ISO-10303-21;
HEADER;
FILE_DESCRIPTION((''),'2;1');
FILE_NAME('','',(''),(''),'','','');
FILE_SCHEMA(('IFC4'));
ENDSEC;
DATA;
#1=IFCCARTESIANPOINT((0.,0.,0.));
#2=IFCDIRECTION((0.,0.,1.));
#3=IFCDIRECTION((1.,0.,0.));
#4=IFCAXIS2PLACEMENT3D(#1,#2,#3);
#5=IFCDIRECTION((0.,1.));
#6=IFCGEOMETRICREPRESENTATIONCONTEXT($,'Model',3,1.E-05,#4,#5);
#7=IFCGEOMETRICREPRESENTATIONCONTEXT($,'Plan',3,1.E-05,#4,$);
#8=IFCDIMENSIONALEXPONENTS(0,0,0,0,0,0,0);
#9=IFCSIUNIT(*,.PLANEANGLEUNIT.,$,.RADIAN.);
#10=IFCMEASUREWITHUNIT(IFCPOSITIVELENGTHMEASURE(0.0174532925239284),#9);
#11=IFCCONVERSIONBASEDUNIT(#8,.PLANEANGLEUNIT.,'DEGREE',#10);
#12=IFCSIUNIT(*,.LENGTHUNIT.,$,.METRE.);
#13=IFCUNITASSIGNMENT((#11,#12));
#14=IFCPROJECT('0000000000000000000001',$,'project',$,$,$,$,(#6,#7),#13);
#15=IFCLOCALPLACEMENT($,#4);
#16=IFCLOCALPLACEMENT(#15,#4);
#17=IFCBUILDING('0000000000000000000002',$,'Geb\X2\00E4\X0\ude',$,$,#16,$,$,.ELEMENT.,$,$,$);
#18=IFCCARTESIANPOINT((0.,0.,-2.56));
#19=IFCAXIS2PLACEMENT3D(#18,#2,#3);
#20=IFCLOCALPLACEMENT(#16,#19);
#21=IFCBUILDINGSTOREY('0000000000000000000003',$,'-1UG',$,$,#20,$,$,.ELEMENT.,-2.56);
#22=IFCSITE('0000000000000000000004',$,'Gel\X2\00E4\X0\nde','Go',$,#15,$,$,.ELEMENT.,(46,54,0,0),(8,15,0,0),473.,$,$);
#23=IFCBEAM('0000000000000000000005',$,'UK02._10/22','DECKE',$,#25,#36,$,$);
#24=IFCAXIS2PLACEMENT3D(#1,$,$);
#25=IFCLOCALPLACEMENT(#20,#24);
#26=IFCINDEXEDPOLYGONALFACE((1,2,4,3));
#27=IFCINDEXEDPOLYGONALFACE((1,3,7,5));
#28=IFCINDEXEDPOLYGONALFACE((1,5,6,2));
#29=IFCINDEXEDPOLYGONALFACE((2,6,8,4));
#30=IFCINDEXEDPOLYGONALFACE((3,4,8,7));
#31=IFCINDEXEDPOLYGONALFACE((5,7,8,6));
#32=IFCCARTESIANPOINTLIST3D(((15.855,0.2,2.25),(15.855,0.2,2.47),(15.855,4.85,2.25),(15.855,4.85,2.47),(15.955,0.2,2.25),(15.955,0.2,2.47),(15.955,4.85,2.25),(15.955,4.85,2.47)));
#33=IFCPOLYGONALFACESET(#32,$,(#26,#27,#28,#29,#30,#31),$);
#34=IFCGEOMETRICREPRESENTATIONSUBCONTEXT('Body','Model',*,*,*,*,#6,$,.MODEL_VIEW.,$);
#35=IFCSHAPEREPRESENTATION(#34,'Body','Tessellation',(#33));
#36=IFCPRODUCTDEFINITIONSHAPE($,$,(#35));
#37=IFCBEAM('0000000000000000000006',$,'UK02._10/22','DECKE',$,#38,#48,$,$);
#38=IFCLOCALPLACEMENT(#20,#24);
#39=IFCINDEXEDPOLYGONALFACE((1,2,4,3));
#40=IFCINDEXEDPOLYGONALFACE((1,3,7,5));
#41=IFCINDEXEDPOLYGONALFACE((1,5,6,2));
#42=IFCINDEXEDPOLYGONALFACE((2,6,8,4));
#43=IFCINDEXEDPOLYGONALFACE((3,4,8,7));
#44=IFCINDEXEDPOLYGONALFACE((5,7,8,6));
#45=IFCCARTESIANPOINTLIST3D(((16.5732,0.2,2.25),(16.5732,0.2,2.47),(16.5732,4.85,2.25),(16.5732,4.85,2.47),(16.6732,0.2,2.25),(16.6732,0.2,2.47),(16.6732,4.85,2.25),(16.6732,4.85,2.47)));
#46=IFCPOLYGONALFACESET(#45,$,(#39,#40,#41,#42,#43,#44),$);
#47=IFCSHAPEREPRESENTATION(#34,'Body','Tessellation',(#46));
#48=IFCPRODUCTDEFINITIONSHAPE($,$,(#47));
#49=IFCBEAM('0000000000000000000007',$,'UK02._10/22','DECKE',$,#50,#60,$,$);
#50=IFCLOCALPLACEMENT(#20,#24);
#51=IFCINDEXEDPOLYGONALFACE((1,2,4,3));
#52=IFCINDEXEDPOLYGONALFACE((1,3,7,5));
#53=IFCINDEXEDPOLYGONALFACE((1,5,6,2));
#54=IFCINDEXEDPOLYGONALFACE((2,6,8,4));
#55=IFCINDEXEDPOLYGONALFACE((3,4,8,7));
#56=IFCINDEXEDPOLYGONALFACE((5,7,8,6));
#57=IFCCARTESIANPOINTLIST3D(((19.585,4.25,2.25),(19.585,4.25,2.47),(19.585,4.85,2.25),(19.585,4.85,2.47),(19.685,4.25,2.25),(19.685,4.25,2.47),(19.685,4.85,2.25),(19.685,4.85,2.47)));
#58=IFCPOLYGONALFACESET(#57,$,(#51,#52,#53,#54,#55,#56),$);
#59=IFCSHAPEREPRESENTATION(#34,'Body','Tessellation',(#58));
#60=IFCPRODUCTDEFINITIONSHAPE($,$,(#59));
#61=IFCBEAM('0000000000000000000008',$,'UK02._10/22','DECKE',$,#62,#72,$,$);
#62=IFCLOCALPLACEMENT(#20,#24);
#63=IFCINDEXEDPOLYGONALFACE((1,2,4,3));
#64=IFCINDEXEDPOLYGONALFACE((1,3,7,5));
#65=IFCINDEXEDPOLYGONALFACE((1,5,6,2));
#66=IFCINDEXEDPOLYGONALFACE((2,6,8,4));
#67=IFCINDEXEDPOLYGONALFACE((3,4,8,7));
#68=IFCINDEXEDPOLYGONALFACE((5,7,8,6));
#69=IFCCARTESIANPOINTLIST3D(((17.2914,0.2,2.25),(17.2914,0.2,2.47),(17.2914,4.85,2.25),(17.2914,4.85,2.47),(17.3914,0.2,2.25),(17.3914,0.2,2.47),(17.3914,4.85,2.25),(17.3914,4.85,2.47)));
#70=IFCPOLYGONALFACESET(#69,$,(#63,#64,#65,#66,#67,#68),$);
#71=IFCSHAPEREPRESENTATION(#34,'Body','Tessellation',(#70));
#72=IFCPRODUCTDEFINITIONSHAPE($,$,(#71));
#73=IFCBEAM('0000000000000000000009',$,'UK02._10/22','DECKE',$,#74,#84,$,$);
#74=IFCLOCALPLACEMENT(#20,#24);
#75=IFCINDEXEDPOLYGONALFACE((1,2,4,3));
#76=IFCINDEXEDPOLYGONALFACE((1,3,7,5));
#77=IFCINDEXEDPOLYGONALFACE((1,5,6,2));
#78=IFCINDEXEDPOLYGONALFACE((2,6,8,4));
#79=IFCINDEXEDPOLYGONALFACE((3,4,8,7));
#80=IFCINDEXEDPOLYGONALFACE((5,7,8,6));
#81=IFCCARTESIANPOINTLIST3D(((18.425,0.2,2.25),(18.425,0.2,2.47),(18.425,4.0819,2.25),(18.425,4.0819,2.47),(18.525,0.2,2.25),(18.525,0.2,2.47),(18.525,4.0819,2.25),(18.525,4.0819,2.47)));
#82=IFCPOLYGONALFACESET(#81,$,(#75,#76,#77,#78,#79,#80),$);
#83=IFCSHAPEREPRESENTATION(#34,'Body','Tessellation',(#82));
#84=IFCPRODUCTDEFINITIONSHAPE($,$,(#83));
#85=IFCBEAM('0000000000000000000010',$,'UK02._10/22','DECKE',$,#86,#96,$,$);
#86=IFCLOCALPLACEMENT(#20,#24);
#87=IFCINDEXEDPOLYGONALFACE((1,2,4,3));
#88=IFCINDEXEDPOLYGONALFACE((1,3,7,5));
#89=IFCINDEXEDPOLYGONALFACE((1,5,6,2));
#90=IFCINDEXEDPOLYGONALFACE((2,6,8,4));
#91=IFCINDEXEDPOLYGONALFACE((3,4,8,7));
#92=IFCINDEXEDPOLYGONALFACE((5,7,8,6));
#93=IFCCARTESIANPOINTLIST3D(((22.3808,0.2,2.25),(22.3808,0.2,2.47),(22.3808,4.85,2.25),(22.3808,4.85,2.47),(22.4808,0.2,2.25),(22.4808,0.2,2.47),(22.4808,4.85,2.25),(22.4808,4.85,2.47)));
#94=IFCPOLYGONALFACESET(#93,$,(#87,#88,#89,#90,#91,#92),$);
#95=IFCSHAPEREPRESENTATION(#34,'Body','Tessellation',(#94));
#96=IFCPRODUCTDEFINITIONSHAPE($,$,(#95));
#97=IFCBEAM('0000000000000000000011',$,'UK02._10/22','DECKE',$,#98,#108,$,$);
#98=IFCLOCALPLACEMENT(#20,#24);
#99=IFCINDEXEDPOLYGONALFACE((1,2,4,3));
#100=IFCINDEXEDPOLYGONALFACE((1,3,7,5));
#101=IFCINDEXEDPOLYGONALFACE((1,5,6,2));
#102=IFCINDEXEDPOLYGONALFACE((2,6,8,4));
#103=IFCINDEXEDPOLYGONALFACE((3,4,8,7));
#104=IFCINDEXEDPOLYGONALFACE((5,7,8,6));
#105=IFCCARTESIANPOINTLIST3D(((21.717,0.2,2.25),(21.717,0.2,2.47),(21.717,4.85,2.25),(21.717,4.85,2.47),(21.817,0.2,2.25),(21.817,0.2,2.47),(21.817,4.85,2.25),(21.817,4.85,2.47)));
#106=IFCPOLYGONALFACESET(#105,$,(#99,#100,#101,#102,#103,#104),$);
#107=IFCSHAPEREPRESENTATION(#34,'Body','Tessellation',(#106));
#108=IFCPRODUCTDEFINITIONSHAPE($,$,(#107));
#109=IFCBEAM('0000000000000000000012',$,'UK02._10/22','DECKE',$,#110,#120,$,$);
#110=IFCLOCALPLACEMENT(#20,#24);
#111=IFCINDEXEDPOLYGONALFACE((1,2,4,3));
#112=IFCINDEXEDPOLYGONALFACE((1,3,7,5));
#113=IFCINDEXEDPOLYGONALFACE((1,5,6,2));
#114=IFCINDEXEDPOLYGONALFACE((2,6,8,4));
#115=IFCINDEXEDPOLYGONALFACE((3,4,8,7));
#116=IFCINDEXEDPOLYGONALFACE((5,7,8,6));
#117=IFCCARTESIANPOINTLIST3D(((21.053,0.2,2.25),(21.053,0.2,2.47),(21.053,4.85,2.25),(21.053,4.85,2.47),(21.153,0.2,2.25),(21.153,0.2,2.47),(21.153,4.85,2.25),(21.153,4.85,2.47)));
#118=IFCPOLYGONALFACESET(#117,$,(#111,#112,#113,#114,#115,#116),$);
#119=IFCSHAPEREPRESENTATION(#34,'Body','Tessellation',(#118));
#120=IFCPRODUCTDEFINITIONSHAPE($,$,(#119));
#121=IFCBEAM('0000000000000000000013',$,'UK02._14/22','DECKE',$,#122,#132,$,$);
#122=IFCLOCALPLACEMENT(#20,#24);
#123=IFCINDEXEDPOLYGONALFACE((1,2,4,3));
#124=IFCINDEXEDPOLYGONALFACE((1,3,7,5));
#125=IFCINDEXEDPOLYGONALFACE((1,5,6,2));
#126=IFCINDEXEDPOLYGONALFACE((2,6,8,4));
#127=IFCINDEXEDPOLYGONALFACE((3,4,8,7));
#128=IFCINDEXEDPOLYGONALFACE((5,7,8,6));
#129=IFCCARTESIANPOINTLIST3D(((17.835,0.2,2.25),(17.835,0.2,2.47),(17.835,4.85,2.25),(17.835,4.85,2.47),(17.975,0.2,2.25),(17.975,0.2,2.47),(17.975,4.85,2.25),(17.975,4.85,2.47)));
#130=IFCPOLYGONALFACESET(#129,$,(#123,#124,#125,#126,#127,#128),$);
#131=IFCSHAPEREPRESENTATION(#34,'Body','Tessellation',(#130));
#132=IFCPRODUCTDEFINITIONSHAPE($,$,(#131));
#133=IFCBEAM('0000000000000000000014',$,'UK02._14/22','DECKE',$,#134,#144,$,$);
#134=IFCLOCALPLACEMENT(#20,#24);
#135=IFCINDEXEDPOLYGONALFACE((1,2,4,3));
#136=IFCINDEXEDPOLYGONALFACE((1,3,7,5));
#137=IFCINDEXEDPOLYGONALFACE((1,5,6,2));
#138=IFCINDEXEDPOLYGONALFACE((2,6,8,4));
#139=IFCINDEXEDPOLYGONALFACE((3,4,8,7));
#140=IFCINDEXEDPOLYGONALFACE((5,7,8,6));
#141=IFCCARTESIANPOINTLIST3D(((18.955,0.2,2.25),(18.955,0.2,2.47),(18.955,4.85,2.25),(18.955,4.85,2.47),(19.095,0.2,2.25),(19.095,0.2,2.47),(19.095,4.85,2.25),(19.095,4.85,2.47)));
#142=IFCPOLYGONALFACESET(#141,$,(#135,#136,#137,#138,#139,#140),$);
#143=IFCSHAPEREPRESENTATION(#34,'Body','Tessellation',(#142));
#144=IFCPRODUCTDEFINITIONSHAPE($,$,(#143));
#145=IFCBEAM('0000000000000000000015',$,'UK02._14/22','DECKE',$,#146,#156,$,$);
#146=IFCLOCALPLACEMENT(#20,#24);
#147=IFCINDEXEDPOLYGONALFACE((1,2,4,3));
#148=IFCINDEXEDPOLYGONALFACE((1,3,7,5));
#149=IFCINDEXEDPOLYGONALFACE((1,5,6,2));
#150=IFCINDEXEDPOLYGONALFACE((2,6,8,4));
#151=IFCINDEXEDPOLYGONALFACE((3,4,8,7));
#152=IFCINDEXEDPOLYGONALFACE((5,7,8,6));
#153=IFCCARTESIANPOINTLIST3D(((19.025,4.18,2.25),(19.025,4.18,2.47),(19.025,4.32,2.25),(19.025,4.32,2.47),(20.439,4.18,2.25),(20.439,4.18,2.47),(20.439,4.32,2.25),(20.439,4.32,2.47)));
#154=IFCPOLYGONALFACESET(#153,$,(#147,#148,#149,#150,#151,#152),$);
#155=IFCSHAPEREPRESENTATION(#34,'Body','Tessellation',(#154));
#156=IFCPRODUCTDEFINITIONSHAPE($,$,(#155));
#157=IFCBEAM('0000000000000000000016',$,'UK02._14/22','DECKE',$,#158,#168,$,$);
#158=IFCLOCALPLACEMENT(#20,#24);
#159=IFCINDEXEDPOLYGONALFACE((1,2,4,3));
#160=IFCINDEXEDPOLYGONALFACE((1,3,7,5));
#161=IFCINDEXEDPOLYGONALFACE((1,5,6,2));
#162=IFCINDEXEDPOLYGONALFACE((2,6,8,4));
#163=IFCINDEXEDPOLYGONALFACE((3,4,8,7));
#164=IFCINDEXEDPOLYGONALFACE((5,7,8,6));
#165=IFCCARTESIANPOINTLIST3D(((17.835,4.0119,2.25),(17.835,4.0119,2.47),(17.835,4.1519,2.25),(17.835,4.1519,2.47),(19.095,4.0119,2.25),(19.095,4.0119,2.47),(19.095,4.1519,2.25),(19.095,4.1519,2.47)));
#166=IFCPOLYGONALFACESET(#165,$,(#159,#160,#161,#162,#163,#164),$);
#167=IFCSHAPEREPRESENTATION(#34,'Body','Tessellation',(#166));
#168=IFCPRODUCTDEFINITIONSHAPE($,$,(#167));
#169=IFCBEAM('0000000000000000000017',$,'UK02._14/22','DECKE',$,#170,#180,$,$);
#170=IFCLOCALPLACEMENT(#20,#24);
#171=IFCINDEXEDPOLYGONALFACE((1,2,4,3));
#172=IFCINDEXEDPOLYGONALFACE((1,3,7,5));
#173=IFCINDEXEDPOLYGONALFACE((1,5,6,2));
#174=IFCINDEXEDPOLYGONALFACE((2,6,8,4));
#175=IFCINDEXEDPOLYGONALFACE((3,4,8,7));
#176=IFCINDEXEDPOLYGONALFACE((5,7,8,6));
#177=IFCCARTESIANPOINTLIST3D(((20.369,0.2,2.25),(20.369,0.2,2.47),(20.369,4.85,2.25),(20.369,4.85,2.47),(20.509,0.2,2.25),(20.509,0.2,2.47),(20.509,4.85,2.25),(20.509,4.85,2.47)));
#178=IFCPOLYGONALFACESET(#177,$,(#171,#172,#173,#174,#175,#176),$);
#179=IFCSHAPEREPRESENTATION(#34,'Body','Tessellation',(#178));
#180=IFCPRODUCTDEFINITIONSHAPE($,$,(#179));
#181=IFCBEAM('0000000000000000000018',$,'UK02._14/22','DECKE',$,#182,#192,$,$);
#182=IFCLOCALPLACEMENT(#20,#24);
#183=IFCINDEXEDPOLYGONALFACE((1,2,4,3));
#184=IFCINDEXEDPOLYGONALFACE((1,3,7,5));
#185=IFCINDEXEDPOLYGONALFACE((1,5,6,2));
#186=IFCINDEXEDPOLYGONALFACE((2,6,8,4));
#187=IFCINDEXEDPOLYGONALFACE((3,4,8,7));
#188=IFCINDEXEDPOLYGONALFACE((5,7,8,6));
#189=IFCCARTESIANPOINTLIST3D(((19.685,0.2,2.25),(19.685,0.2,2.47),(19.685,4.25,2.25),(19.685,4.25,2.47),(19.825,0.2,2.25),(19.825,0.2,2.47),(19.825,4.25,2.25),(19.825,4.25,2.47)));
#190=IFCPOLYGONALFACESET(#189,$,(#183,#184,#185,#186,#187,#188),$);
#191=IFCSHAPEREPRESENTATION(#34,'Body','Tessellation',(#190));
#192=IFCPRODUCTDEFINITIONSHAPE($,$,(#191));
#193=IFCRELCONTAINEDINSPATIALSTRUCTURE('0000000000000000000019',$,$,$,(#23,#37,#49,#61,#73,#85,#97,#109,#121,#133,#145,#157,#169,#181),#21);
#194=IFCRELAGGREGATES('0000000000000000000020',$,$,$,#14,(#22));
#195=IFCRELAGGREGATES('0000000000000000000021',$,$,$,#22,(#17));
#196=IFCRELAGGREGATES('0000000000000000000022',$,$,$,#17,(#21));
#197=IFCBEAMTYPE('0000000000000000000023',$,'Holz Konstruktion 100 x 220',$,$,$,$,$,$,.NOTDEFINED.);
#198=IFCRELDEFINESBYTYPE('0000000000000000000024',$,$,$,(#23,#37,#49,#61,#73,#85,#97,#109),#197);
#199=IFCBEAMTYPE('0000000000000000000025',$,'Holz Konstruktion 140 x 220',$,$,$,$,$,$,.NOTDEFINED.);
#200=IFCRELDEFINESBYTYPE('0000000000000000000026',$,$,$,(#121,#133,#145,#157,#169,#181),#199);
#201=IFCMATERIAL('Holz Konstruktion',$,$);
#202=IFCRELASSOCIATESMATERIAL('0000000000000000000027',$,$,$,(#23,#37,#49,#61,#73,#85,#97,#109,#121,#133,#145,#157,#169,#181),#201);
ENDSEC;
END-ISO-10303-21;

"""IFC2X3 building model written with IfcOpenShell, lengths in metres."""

from ifc_helpers import new_model, entity, si_unit, converted_unit, direction, frame, frame_2d, origin_with_axes, place, context, subcontext, project, spatial, rectangle, extrude, material, type_object, element, save


model = new_model("IFC2X3")

# Units and contexts
model_context = context("Model", 3, precision=1e-05, world=origin_with_axes(), true_north=direction((0.0, 1.0)))
plan_context = context("Plan", 3, precision=1e-05, world=origin_with_axes())
body_context = subcontext(model_context, "Body", "Model", "MODEL_VIEW")
ifc_project = project(units=[converted_unit("PLANEANGLEUNIT", "DEGREE", entity("IfcPositiveLengthMeasure", 0.0174532925239284), si_unit("PLANEANGLEUNIT", "RADIAN"), dimensions=[0, 0, 0, 0, 0, 0, 0]), si_unit("LENGTHUNIT", "METRE")], contexts=[model_context, plan_context])

# Site, building, storey
site_placement = place(None, origin_with_axes())
site = spatial("IfcSite", under=ifc_project, at=site_placement, Name="Gelände", Description="Go", CompositionType="ELEMENT", RefLatitude=(46, 54, 0, 0), RefLongitude=(8, 15, 0, 0), RefElevation=473.0)
building_placement = place(site_placement, origin_with_axes())
building = spatial("IfcBuilding", under=site, at=building_placement, Name="Gebäude", CompositionType="ELEMENT")
storey_placement = place(building_placement, frame((0.0, 0.0, -2.56), z_axis=(0.0, 0.0, 1.0), x_axis=(1.0, 0.0, 0.0)))
storey = spatial("IfcBuildingStorey", under=building, at=storey_placement, Name="-1UG", CompositionType="ELEMENT", Elevation=-2.56)

# Beams
ifc_material_1 = material(Name="Holz Konstruktion")
beam_type_1 = type_object("IfcBeamType", Name="Holz Konstruktion 100 x 220", PredefinedType="NOTDEFINED")
for number, where, z_axis, x_axis, name in (
    (1, (15.905, 0.2, 2.47), (0.0, 0.0, 1.0), (1.0, 0.0, 0.0), "UK02._10/22"),
    (2, (16.6232, 0.2, 2.47), (0.0, 0.0, 1.0), (1.0, 0.0, 0.0), "UK02._10/22"),
):
    element("IfcBeam", number, at=place(storey_placement, frame(where, z_axis=z_axis, x_axis=x_axis)), inside=storey, type_object=beam_type_1, material=ifc_material_1, Name=name, Description="DECKE", context=body_context, shape_type="SweptSolid", body=[
        extrude(rectangle(XDim=0.22, YDim=0.1, at=frame_2d((-0.11, 0.0), x_axis=(1.0, 0.0))), frame((0.0, 0.0, 0.0), z_axis=(0.0, 1.0, 0.0), x_axis=(0.0, 0.0, 1.0)), (0.0, 0.0, 1.0), 4.65),
    ])
beam_1_placement = place(storey_placement, frame((19.635, 4.25, 2.47), z_axis=(0.0, 0.0, 1.0), x_axis=(1.0, 0.0, 0.0)))
element("IfcBeam", 3, at=beam_1_placement, inside=storey, type_object=beam_type_1, material=ifc_material_1, Name="UK02._10/22", Description="DECKE", context=body_context, shape_type="SweptSolid", body=[
    extrude(rectangle(XDim=0.22, YDim=0.1, at=frame_2d((-0.11, 0.0), x_axis=(1.0, 0.0))), frame((0.0, 0.0, 0.0), z_axis=(0.0, 1.0, 0.0), x_axis=(0.0, 0.0, 1.0)), (0.0, 0.0, 1.0), 0.6),
])
beam_2_placement = place(storey_placement, frame((17.3414, 0.2, 2.47), z_axis=(0.0, 0.0, 1.0), x_axis=(1.0, 0.0, 0.0)))
element("IfcBeam", 4, at=beam_2_placement, inside=storey, type_object=beam_type_1, material=ifc_material_1, Name="UK02._10/22", Description="DECKE", context=body_context, shape_type="SweptSolid", body=[
    extrude(rectangle(XDim=0.22, YDim=0.1, at=frame_2d((-0.11, 0.0), x_axis=(1.0, 0.0))), frame((0.0, 0.0, 0.0), z_axis=(0.0, 1.0, 0.0), x_axis=(0.0, 0.0, 1.0)), (0.0, 0.0, 1.0), 4.65),
])
beam_3_placement = place(storey_placement, frame((18.475, 0.2, 2.47), z_axis=(0.0, 0.0, 1.0), x_axis=(1.0, 0.0, 0.0)))
element("IfcBeam", 5, at=beam_3_placement, inside=storey, type_object=beam_type_1, material=ifc_material_1, Name="UK02._10/22", Description="DECKE", context=body_context, shape_type="SweptSolid", body=[
    extrude(rectangle(XDim=0.22, YDim=0.1, at=frame_2d((-0.11, 0.0), x_axis=(1.0, 0.0))), frame((0.0, 0.0, 0.0), z_axis=(0.0, 1.0, 0.0), x_axis=(0.0, 0.0, 1.0)), (0.0, 0.0, 1.0), 3.8819),
])
for number, where, z_axis, x_axis, name in (
    (6, (22.4308, 0.2, 2.47), (0.0, 0.0, 1.0), (1.0, 0.0, 0.0), "UK02._10/22"),
    (7, (21.767, 0.2, 2.47), (0.0, 0.0, 1.0), (1.0, 0.0, 0.0), "UK02._10/22"),
    (8, (21.103, 0.2, 2.47), (0.0, 0.0, 1.0), (1.0, 0.0, 0.0), "UK02._10/22"),
):
    element("IfcBeam", number, at=place(storey_placement, frame(where, z_axis=z_axis, x_axis=x_axis)), inside=storey, type_object=beam_type_1, material=ifc_material_1, Name=name, Description="DECKE", context=body_context, shape_type="SweptSolid", body=[
        extrude(rectangle(XDim=0.22, YDim=0.1, at=frame_2d((-0.11, 0.0), x_axis=(1.0, 0.0))), frame((0.0, 0.0, 0.0), z_axis=(0.0, 1.0, 0.0), x_axis=(0.0, 0.0, 1.0)), (0.0, 0.0, 1.0), 4.65),
    ])
beam_type_2 = type_object("IfcBeamType", Name="Holz Konstruktion 140 x 220", PredefinedType="NOTDEFINED")
for number, where, z_axis, x_axis, name in (
    (9, (17.905, 0.2, 2.47), (0.0, 0.0, 1.0), (1.0, 0.0, 0.0), "UK02._14/22"),
    (10, (19.025, 0.2, 2.47), (0.0, 0.0, 1.0), (1.0, 0.0, 0.0), "UK02._14/22"),
):
    element("IfcBeam", number, at=place(storey_placement, frame(where, z_axis=z_axis, x_axis=x_axis)), inside=storey, type_object=beam_type_2, material=ifc_material_1, Name=name, Description="DECKE", context=body_context, shape_type="SweptSolid", body=[
        extrude(rectangle(XDim=0.22, YDim=0.14, at=frame_2d((-0.11, 0.0), x_axis=(1.0, 0.0))), frame((0.0, 0.0, 0.0), z_axis=(0.0, 1.0, 0.0), x_axis=(0.0, 0.0, 1.0)), (0.0, 0.0, 1.0), 4.65),
    ])
beam_4_placement = place(storey_placement, frame((19.025, 4.25, 2.47), z_axis=(0.0, 0.0, 1.0), x_axis=(0.0, -1.0, 0.0)))
element("IfcBeam", 11, at=beam_4_placement, inside=storey, type_object=beam_type_2, material=ifc_material_1, Name="UK02._14/22", Description="DECKE", context=body_context, shape_type="SweptSolid", body=[
    extrude(rectangle(XDim=0.22, YDim=0.14, at=frame_2d((-0.11, 0.0), x_axis=(1.0, 0.0))), frame((0.0, 0.0, 0.0), z_axis=(0.0, 1.0, 0.0), x_axis=(0.0, 0.0, 1.0)), (0.0, 0.0, 1.0), 1.414),
])
beam_5_placement = place(storey_placement, frame((17.835, 4.0819, 2.47), z_axis=(0.0, 0.0, 1.0), x_axis=(0.0, -1.0, 0.0)))
element("IfcBeam", 12, at=beam_5_placement, inside=storey, type_object=beam_type_2, material=ifc_material_1, Name="UK02._14/22", Description="DECKE", context=body_context, shape_type="SweptSolid", body=[
    extrude(rectangle(XDim=0.22, YDim=0.14, at=frame_2d((-0.11, 0.0), x_axis=(1.0, 0.0))), frame((0.0, 0.0, 0.0), z_axis=(0.0, 1.0, 0.0), x_axis=(0.0, 0.0, 1.0)), (0.0, 0.0, 1.0), 1.26),
])
beam_6_placement = place(storey_placement, frame((20.439, 0.2, 2.47), z_axis=(0.0, 0.0, 1.0), x_axis=(1.0, 0.0, 0.0)))
element("IfcBeam", 13, at=beam_6_placement, inside=storey, type_object=beam_type_2, material=ifc_material_1, Name="UK02._14/22", Description="DECKE", context=body_context, shape_type="SweptSolid", body=[
    extrude(rectangle(XDim=0.22, YDim=0.14, at=frame_2d((-0.11, 0.0), x_axis=(1.0, 0.0))), frame((0.0, 0.0, 0.0), z_axis=(0.0, 1.0, 0.0), x_axis=(0.0, 0.0, 1.0)), (0.0, 0.0, 1.0), 4.65),
])
beam_7_placement = place(storey_placement, frame((19.755, 0.2, 2.47), z_axis=(0.0, 0.0, 1.0), x_axis=(1.0, 0.0, 0.0)))
element("IfcBeam", 14, at=beam_7_placement, inside=storey, type_object=beam_type_2, material=ifc_material_1, Name="UK02._14/22", Description="DECKE", context=body_context, shape_type="SweptSolid", body=[
    extrude(rectangle(XDim=0.22, YDim=0.14, at=frame_2d((-0.11, 0.0), x_axis=(1.0, 0.0))), frame((0.0, 0.0, 0.0), z_axis=(0.0, 1.0, 0.0), x_axis=(0.0, 0.0, 1.0)), (0.0, 0.0, 1.0), 4.05),
])

save(model, "model.ifc")
